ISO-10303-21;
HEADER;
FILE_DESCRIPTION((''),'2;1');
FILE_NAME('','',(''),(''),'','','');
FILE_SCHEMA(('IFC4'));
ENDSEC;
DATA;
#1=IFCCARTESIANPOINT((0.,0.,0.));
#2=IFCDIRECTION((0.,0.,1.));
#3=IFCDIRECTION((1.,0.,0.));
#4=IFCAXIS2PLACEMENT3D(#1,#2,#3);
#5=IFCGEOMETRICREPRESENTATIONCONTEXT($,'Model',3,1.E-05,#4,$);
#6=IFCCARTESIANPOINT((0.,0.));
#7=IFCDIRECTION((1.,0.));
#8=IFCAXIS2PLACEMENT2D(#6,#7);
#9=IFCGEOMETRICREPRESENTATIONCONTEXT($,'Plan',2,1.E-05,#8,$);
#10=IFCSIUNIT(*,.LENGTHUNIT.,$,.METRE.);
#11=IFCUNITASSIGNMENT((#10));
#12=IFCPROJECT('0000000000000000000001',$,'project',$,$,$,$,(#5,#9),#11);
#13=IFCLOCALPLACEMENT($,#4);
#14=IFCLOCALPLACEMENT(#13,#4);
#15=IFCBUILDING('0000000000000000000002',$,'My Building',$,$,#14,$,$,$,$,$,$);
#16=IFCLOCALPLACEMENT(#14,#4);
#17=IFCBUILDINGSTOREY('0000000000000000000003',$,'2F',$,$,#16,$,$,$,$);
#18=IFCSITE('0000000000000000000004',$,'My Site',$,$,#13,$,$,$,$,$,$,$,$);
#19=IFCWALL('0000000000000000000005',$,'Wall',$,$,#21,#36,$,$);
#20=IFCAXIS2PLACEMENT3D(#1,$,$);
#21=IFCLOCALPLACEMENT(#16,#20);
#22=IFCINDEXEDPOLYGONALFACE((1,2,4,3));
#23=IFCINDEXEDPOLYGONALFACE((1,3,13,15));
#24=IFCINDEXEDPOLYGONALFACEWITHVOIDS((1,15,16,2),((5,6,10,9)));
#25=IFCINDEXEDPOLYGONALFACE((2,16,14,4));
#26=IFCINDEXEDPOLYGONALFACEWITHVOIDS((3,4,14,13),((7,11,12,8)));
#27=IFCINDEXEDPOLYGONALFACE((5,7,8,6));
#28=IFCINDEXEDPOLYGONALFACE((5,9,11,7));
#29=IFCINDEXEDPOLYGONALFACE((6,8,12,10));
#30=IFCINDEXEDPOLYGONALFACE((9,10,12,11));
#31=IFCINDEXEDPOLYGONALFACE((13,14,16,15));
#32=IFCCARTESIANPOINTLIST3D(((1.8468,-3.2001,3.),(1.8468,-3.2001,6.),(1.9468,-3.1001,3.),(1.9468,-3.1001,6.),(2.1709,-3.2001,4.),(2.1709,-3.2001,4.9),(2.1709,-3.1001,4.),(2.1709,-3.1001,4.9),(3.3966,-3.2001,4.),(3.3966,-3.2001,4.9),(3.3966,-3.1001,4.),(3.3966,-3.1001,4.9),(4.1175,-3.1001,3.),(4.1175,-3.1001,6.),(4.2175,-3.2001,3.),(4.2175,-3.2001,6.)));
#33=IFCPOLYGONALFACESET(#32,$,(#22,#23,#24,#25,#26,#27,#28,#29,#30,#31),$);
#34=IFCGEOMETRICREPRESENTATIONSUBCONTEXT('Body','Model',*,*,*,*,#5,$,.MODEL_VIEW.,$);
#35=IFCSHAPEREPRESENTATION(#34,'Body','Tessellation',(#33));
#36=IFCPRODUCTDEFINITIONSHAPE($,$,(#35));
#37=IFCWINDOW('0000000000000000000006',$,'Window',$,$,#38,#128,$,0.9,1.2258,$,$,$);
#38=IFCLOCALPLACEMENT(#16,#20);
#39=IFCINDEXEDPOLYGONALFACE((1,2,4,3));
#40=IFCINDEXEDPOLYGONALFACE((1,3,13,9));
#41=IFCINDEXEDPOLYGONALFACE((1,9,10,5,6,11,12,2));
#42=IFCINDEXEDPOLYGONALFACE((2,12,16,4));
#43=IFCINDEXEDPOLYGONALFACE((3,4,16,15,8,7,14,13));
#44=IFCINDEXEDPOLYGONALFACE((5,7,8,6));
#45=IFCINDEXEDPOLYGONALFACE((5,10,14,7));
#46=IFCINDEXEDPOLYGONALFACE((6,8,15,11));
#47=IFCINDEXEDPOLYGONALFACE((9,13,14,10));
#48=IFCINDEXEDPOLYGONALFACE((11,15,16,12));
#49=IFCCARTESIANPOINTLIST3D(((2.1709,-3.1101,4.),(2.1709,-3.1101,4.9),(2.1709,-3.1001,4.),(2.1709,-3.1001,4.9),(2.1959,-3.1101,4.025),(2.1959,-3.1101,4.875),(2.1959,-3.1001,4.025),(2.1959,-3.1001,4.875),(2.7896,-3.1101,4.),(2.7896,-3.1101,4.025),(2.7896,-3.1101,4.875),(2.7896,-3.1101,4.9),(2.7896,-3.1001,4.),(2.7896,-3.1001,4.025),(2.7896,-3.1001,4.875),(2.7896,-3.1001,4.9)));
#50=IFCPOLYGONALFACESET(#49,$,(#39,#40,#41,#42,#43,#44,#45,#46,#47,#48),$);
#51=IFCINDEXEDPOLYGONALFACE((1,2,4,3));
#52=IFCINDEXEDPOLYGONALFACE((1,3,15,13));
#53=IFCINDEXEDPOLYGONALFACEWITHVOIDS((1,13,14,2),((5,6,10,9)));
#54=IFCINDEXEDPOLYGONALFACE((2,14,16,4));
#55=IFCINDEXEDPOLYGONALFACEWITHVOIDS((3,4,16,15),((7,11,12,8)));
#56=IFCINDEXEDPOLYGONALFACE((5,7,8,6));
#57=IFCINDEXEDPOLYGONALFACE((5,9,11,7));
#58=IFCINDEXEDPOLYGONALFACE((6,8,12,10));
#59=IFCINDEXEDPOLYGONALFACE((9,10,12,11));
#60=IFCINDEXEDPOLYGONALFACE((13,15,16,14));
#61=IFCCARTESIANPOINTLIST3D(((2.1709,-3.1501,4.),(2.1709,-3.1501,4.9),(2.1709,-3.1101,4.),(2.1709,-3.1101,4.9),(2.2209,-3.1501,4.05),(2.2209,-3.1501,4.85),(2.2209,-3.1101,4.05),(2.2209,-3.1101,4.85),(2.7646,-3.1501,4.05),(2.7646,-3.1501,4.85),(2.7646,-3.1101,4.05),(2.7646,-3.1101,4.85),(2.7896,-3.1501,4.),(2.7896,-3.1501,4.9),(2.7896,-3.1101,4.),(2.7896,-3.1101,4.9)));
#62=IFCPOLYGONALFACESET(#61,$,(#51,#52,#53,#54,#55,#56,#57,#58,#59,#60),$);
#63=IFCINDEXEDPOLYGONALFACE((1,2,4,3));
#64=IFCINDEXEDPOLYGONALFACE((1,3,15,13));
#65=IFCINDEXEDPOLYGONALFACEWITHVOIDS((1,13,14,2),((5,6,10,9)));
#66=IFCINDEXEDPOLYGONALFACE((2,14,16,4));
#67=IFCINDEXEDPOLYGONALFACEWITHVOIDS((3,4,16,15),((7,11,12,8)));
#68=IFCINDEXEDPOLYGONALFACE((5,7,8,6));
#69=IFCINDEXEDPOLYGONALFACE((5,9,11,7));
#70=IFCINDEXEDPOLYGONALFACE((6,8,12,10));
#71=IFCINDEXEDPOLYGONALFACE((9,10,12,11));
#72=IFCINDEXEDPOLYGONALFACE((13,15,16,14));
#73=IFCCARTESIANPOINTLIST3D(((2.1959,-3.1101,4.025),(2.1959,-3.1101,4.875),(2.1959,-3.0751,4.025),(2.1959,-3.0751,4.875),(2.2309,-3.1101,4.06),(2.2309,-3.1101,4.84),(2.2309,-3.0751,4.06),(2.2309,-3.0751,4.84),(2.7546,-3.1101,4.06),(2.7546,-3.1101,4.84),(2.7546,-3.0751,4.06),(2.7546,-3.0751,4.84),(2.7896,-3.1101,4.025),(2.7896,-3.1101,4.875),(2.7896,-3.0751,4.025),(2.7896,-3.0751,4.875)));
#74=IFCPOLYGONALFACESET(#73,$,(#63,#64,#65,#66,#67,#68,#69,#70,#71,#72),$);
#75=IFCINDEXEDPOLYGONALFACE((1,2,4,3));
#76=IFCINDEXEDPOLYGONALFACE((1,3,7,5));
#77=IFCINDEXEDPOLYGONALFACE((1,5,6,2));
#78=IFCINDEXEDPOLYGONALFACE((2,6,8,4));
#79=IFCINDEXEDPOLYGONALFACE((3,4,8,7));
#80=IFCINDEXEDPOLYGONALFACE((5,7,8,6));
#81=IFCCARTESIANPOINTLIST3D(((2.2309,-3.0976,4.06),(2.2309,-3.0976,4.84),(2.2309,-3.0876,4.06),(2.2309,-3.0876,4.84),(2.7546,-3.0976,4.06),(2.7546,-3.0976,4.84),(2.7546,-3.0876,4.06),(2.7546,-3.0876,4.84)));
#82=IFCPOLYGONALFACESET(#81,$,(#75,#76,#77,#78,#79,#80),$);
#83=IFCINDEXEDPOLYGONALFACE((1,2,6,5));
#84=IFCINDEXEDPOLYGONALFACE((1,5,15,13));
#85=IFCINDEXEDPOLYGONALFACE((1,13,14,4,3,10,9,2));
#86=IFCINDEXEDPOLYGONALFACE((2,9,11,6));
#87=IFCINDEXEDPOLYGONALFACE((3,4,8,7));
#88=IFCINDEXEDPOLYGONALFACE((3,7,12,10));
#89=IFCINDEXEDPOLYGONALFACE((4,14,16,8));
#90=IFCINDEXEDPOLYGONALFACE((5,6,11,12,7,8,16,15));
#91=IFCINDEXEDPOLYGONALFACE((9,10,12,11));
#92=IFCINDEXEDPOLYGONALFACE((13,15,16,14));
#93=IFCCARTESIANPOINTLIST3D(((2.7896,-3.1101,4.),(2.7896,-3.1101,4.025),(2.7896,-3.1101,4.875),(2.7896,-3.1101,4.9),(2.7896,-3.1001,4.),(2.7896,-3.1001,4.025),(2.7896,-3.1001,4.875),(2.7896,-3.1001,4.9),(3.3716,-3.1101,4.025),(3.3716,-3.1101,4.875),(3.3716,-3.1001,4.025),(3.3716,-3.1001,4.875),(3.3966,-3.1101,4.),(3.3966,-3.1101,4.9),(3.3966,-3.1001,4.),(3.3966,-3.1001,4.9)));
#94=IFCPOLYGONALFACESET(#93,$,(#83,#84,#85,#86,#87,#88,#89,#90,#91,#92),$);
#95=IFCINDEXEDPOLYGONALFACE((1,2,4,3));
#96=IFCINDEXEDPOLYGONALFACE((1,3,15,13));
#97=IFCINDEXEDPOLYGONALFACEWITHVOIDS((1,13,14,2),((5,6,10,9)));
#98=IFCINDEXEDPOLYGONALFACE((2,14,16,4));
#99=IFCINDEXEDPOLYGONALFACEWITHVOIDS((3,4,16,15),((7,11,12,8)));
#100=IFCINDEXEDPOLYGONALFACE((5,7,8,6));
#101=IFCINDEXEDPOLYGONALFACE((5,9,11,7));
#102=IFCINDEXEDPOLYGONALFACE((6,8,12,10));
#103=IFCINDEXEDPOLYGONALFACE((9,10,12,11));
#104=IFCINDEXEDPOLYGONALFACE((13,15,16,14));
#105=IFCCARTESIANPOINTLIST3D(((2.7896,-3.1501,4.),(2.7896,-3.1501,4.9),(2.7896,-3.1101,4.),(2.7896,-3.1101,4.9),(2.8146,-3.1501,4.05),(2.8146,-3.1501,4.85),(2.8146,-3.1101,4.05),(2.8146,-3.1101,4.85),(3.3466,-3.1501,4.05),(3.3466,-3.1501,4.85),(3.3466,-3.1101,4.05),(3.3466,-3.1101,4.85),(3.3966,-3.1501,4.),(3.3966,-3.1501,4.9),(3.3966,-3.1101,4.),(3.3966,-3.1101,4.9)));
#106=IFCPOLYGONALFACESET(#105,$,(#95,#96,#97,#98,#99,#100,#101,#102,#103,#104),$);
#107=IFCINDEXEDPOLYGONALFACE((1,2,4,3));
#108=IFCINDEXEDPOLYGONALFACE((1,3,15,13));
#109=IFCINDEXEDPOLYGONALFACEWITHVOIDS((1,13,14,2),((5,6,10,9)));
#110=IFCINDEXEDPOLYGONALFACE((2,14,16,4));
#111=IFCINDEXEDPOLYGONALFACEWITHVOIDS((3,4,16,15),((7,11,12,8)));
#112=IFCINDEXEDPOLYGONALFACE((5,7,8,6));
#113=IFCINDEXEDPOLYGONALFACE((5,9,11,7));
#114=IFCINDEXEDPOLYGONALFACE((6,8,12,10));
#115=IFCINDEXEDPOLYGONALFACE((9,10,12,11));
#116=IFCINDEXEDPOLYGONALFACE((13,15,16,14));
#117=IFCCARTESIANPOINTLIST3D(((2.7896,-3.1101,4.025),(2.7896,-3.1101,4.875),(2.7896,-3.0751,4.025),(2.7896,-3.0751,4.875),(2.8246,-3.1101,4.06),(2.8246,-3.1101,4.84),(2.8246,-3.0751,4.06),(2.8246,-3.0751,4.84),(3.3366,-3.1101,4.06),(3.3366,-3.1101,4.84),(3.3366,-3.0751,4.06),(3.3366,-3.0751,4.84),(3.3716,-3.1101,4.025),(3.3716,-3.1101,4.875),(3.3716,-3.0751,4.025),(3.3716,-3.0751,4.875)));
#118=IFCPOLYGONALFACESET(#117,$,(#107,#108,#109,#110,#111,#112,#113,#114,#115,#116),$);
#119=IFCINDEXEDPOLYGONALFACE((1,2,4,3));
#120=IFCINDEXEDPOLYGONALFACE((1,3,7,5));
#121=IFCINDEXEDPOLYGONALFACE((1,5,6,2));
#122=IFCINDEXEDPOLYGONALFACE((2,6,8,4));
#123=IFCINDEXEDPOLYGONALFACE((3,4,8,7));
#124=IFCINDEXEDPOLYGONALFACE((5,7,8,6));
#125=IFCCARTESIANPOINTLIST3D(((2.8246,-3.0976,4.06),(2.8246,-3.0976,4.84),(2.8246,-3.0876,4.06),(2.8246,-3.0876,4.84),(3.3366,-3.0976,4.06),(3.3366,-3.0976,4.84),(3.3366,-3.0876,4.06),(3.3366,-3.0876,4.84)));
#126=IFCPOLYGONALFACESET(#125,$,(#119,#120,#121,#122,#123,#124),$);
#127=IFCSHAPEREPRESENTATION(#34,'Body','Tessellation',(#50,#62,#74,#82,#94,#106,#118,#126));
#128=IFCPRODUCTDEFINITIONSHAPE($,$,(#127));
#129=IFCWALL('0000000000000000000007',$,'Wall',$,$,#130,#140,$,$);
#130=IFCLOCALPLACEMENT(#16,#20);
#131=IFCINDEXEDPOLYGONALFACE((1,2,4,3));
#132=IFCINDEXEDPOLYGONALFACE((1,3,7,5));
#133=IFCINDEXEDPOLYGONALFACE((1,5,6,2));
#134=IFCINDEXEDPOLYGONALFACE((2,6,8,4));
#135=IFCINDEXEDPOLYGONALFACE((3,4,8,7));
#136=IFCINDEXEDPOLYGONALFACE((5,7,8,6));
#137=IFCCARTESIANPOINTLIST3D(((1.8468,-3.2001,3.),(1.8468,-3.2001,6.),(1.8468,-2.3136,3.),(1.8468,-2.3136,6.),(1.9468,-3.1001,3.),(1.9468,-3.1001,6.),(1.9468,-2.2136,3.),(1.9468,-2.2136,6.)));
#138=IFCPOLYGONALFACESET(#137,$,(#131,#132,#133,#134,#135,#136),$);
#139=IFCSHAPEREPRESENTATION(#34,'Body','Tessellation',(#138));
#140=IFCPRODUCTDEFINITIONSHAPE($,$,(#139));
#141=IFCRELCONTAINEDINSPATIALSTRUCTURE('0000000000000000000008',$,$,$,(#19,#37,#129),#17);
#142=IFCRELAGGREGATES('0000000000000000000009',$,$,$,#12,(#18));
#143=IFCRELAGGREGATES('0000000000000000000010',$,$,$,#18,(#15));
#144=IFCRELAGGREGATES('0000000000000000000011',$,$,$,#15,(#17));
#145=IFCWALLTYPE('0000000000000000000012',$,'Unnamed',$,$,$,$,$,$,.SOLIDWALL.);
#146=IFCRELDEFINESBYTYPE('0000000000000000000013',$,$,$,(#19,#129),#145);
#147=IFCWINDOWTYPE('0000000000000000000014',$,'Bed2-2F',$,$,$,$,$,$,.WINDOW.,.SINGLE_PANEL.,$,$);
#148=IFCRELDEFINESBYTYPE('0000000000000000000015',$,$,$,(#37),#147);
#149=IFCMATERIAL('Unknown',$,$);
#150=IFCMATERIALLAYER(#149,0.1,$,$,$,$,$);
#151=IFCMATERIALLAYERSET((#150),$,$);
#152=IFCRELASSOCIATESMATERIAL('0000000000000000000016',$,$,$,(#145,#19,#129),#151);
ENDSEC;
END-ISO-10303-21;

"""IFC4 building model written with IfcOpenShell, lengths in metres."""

from ifc_helpers import new_model, entity, si_unit, frame, origin_with_axes, origin_2d_with_axis, place, context, subcontext, project, spatial, line, indexed_curve, outline, extrude, shape, source, transform, mapped, material, layer, layer_set, layer_usage, type_object, type_shapes, element, fill, save


model = new_model("IFC4")

# Units and contexts
model_context = context("Model", 3, precision=1e-05, world=origin_with_axes())
plan_context = context("Plan", 2, precision=1e-05, world=origin_2d_with_axis())
body_context_1 = subcontext(model_context, "Body", "Model", "MODEL_VIEW")
body_context_2 = subcontext(plan_context, "Body", "Plan", "PLAN_VIEW")
ifc_project = project(units=[si_unit("LENGTHUNIT", "METRE")], contexts=[model_context, plan_context])

# Site, building, storey
site_placement = place(None, origin_with_axes())
site = spatial("IfcSite", under=ifc_project, at=site_placement, Name="My Site")
building_placement = place(site_placement, origin_with_axes())
building = spatial("IfcBuilding", under=site, at=building_placement, Name="My Building")
storey_placement = place(building_placement, origin_with_axes())
storey = spatial("IfcBuildingStorey", under=building, at=storey_placement, Name="2F")

# Shared definitions
ifc_material = material(Name="Unknown")

# Wall, opening, window
ifc_layer = layer(ifc_material, 0.1)
ifc_layer_set = layer_set([ifc_layer])
ifc_layer_usage_1 = layer_usage(ifc_layer_set, "AXIS2", "POSITIVE", 0.0)
wall_type = type_object("IfcWallType", Name="Unnamed", PredefinedType="SOLIDWALL", material=ifc_layer_set)
wall_1_placement = place(storey_placement, frame((4.1175, -3.1001, 3.0), z_axis=(0.0, 0.0, 1.0), x_axis=(-1.0, 0.0, 0.0)))
wall_1 = element("IfcWall", 1, at=wall_1_placement, inside=storey, type_object=wall_type, material=ifc_layer_usage_1, Name="Wall", context=body_context_1, shape_type="SweptSolid", body=[
    extrude(outline(indexed_curve([(0.0, 0.0), (-0.1, 0.1), (2.2706, 0.1), (2.1706, 0.0)], segments=[line(1, 2, 3, 4, 1)])), origin_with_axes(), (0.0, 0.0, 1.0), 3.0),
])
shared_shape_1 = source(origin_with_axes(), body_context_1, "Body", "SweptSolid", [
    extrude(outline(indexed_curve([(0.0, 0.0), (1.2258, 0.0), (1.2258, 0.9), (0.0, 0.9)], segments=[line(1, 2, 3, 4, 1)])), frame((0.0, -0.6, 0.0), z_axis=(0.0, -1.0, 0.0), x_axis=(1.0, 0.0, 0.0)), (0.0, 0.0, -1.0), 1.2),
])
opening_1_placement = place(wall_1_placement, frame((1.9466, 0.1, 1.0), z_axis=(0.0, 0.0, 1.0), x_axis=(-1.0, 0.0, 0.0)))
opening_1 = element("IfcOpeningElement", 2, at=opening_1_placement, cuts=wall_1, PredefinedType="OPENING", context=body_context_1, shape_type="MappedRepresentation", body=[
    mapped(shared_shape_1, transform((0.0, 0.0, 0.0), x_axis=(1.0, 0.0, 0.0), y_axis=(0.0, 1.0, 0.0), z_axis=(0.0, 0.0, 1.0), scale=1.0)),
])
window_type_1 = type_object("IfcWindowType", Name="Bed2-2F", PartitioningType="SINGLE_PANEL", PredefinedType="WINDOW")
shared_shape_2 = source(origin_with_axes(), body_context_1, "Body", "SweptSolid", [
    extrude(outline(indexed_curve([(0.6187, 0.0), (0.0, 0.0), (0.0, 0.9), (0.6187, 0.9), (0.6187, 0.875), (0.025, 0.875), (0.025, 0.025), (0.6187, 0.025)], segments=[line(1, 2, 3, 4, 5, 6, 7, 8, 1)])), frame((0.0, 0.09, 0.0), z_axis=(0.0, -1.0, 0.0), x_axis=(1.0, 0.0, 0.0)), (0.0, 0.0, -1.0), 0.01),
    extrude(outline(indexed_curve([(0.0, 0.0), (0.6187, 0.0), (0.6187, 0.9), (0.0, 0.9)], segments=[line(1, 2, 3, 4, 1)]), holes=[indexed_curve([(0.05, 0.05), (0.5937, 0.05), (0.5937, 0.85), (0.05, 0.85)], segments=[line(1, 2, 3, 4, 1)])]), frame((0.0, 0.05, 0.0), z_axis=(0.0, -1.0, 0.0), x_axis=(1.0, 0.0, 0.0)), (0.0, 0.0, -1.0), 0.04),
    extrude(outline(indexed_curve([(0.0, 0.0), (0.5937, 0.0), (0.5937, 0.85), (0.0, 0.85)], segments=[line(1, 2, 3, 4, 1)]), holes=[indexed_curve([(0.035, 0.035), (0.5587, 0.035), (0.5587, 0.815), (0.035, 0.815)], segments=[line(1, 2, 3, 4, 1)])]), frame((0.025, 0.09, 0.025), z_axis=(0.0, -1.0, 0.0), x_axis=(1.0, 0.0, 0.0)), (0.0, 0.0, -1.0), 0.035),
    extrude(outline(indexed_curve([(0.035, 0.035), (0.5587, 0.035), (0.5587, 0.815), (0.035, 0.815)], segments=[line(1, 2, 3, 4, 1)])), frame((0.025, 0.1025, 0.025), z_axis=(0.0, -1.0, 0.0), x_axis=(1.0, 0.0, 0.0)), (0.0, 0.0, -1.0), 0.01),
    extrude(outline(indexed_curve([(0.0, 0.9), (0.6071, 0.9), (0.6071, 0.0), (0.0, 0.0), (0.0, 0.025), (0.5821, 0.025), (0.5821, 0.875), (0.0, 0.875)], segments=[line(1, 2, 3, 4, 5, 6, 7, 8, 1)])), frame((0.6187, 0.09, 0.0), z_axis=(0.0, -1.0, 0.0), x_axis=(1.0, 0.0, 0.0)), (0.0, 0.0, -1.0), 0.01),
    extrude(outline(indexed_curve([(0.0, 0.0), (0.6071, 0.0), (0.6071, 0.9), (0.0, 0.9)], segments=[line(1, 2, 3, 4, 1)]), holes=[indexed_curve([(0.025, 0.05), (0.5571, 0.05), (0.5571, 0.85), (0.025, 0.85)], segments=[line(1, 2, 3, 4, 1)])]), frame((0.6187, 0.05, 0.0), z_axis=(0.0, -1.0, 0.0), x_axis=(1.0, 0.0, 0.0)), (0.0, 0.0, -1.0), 0.04),
    extrude(outline(indexed_curve([(0.0, 0.0), (0.5821, 0.0), (0.5821, 0.85), (0.0, 0.85)], segments=[line(1, 2, 3, 4, 1)]), holes=[indexed_curve([(0.035, 0.035), (0.5471, 0.035), (0.5471, 0.815), (0.035, 0.815)], segments=[line(1, 2, 3, 4, 1)])]), frame((0.6187, 0.09, 0.025), z_axis=(0.0, -1.0, 0.0), x_axis=(1.0, 0.0, 0.0)), (0.0, 0.0, -1.0), 0.035),
    extrude(outline(indexed_curve([(0.035, 0.035), (0.5471, 0.035), (0.5471, 0.815), (0.035, 0.815)], segments=[line(1, 2, 3, 4, 1)])), frame((0.6187, 0.1025, 0.025), z_axis=(0.0, -1.0, 0.0), x_axis=(1.0, 0.0, 0.0)), (0.0, 0.0, -1.0), 0.01),
])
shared_shape_3 = source(origin_with_axes(), body_context_2, "Body", "Curve2D", [
    entity("IfcIndexedPolyCurve", entity("IfcCartesianPointList2D", [[0.05, 0.05], [0.5937, 0.05]])),
    entity("IfcIndexedPolyCurve", entity("IfcCartesianPointList2D", [[0.0, 0.1], [0.025, 0.1], [0.025, 0.09], [0.05, 0.09], [0.05, 0.05], [0.0, 0.05]]), [entity("IfcLineIndex", [1, 2, 3, 4, 5, 6, 1])]),
    entity("IfcIndexedPolyCurve", entity("IfcCartesianPointList2D", [[0.6187, 0.1], [0.6187, 0.1], [0.6187, 0.09], [0.5937, 0.09], [0.5937, 0.05], [0.6187, 0.05]])),
    entity("IfcIndexedPolyCurve", entity("IfcCartesianPointList2D", [[0.025, 0.09], [0.06, 0.09], [0.06, 0.125], [0.025, 0.125]]), [entity("IfcLineIndex", [1, 2, 3, 4, 1])]),
    entity("IfcIndexedPolyCurve", entity("IfcCartesianPointList2D", [[0.6187, 0.09], [0.5837, 0.09], [0.5837, 0.125], [0.6187, 0.125]]), [entity("IfcLineIndex", [1, 2, 3, 4, 1])]),
    entity("IfcIndexedPolyCurve", entity("IfcCartesianPointList2D", [[0.06, 0.09], [0.5837, 0.09]])),
    entity("IfcIndexedPolyCurve", entity("IfcCartesianPointList2D", [[0.06, 0.125], [0.5837, 0.125]])),
    entity("IfcIndexedPolyCurve", entity("IfcCartesianPointList2D", [[0.06, 0.1075], [0.5837, 0.1075]])),
    entity("IfcIndexedPolyCurve", entity("IfcCartesianPointList2D", [[0.6437, 0.05], [1.1758, 0.05]])),
    entity("IfcIndexedPolyCurve", entity("IfcCartesianPointList2D", [[0.6187, 0.1], [0.6187, 0.1], [0.6187, 0.09], [0.6437, 0.09], [0.6437, 0.05], [0.6187, 0.05]])),
    entity("IfcIndexedPolyCurve", entity("IfcCartesianPointList2D", [[1.2258, 0.1], [1.2008, 0.1], [1.2008, 0.09], [1.1758, 0.09], [1.1758, 0.05], [1.2258, 0.05]]), [entity("IfcLineIndex", [1, 2, 3, 4, 5, 6, 1])]),
    entity("IfcIndexedPolyCurve", entity("IfcCartesianPointList2D", [[0.6187, 0.09], [0.6537, 0.09], [0.6537, 0.125], [0.6187, 0.125]]), [entity("IfcLineIndex", [1, 2, 3, 4, 1])]),
    entity("IfcIndexedPolyCurve", entity("IfcCartesianPointList2D", [[1.2008, 0.09], [1.1658, 0.09], [1.1658, 0.125], [1.2008, 0.125]]), [entity("IfcLineIndex", [1, 2, 3, 4, 1])]),
    entity("IfcIndexedPolyCurve", entity("IfcCartesianPointList2D", [[0.6537, 0.09], [1.1658, 0.09]])),
    entity("IfcIndexedPolyCurve", entity("IfcCartesianPointList2D", [[0.6537, 0.125], [1.1658, 0.125]])),
    entity("IfcIndexedPolyCurve", entity("IfcCartesianPointList2D", [[0.6537, 0.1075], [1.1658, 0.1075]])),
])
type_shapes(window_type_1, [shared_shape_2, shared_shape_3])
window_1_placement = place(opening_1_placement, frame((0.0, 0.0, 0.0), z_axis=(0.0, 0.0, 1.0), x_axis=(1.0, 0.0, 0.0)))
window_1 = element("IfcWindow", 3, at=window_1_placement, inside=storey, type_object=window_type_1, Name="Window", OverallHeight=0.9, OverallWidth=1.2258, shapes=[
    shape(body_context_1, "Body", "MappedRepresentation", [mapped(shared_shape_2, transform((0.0, 0.0, 0.0), x_axis=(1.0, 0.0, 0.0), y_axis=(0.0, 1.0, 0.0), z_axis=(0.0, 0.0, 1.0), scale=1.0))]),
    shape(body_context_2, "Body", "MappedRepresentation", [mapped(shared_shape_3, transform((0.0, 0.0, 0.0), x_axis=(1.0, 0.0, 0.0), y_axis=(0.0, 1.0, 0.0), z_axis=(0.0, 0.0, 1.0), scale=1.0))]),
])
fill(opening_1, window_1)

# Wall
ifc_layer_usage_2 = layer_usage(ifc_layer_set, "AXIS2", "POSITIVE", 0.0)
wall_2_placement = place(storey_placement, frame((1.9468, -3.1001, 3.0), z_axis=(0.0, 0.0, 1.0), x_axis=(0.000001, 1.0, 0.0)))
element("IfcWall", 4, at=wall_2_placement, inside=storey, type_object=wall_type, material=ifc_layer_usage_2, Name="Wall", context=body_context_1, shape_type="SweptSolid", body=[
    extrude(outline(indexed_curve([(0.0, 0.0), (-0.1, 0.1), (0.7865, 0.1), (0.8865, 0.0)], segments=[line(1, 2, 3, 4, 1)])), origin_with_axes(), (0.0, 0.0, 1.0), 3.0),
])

save(model, "model.ifc")
